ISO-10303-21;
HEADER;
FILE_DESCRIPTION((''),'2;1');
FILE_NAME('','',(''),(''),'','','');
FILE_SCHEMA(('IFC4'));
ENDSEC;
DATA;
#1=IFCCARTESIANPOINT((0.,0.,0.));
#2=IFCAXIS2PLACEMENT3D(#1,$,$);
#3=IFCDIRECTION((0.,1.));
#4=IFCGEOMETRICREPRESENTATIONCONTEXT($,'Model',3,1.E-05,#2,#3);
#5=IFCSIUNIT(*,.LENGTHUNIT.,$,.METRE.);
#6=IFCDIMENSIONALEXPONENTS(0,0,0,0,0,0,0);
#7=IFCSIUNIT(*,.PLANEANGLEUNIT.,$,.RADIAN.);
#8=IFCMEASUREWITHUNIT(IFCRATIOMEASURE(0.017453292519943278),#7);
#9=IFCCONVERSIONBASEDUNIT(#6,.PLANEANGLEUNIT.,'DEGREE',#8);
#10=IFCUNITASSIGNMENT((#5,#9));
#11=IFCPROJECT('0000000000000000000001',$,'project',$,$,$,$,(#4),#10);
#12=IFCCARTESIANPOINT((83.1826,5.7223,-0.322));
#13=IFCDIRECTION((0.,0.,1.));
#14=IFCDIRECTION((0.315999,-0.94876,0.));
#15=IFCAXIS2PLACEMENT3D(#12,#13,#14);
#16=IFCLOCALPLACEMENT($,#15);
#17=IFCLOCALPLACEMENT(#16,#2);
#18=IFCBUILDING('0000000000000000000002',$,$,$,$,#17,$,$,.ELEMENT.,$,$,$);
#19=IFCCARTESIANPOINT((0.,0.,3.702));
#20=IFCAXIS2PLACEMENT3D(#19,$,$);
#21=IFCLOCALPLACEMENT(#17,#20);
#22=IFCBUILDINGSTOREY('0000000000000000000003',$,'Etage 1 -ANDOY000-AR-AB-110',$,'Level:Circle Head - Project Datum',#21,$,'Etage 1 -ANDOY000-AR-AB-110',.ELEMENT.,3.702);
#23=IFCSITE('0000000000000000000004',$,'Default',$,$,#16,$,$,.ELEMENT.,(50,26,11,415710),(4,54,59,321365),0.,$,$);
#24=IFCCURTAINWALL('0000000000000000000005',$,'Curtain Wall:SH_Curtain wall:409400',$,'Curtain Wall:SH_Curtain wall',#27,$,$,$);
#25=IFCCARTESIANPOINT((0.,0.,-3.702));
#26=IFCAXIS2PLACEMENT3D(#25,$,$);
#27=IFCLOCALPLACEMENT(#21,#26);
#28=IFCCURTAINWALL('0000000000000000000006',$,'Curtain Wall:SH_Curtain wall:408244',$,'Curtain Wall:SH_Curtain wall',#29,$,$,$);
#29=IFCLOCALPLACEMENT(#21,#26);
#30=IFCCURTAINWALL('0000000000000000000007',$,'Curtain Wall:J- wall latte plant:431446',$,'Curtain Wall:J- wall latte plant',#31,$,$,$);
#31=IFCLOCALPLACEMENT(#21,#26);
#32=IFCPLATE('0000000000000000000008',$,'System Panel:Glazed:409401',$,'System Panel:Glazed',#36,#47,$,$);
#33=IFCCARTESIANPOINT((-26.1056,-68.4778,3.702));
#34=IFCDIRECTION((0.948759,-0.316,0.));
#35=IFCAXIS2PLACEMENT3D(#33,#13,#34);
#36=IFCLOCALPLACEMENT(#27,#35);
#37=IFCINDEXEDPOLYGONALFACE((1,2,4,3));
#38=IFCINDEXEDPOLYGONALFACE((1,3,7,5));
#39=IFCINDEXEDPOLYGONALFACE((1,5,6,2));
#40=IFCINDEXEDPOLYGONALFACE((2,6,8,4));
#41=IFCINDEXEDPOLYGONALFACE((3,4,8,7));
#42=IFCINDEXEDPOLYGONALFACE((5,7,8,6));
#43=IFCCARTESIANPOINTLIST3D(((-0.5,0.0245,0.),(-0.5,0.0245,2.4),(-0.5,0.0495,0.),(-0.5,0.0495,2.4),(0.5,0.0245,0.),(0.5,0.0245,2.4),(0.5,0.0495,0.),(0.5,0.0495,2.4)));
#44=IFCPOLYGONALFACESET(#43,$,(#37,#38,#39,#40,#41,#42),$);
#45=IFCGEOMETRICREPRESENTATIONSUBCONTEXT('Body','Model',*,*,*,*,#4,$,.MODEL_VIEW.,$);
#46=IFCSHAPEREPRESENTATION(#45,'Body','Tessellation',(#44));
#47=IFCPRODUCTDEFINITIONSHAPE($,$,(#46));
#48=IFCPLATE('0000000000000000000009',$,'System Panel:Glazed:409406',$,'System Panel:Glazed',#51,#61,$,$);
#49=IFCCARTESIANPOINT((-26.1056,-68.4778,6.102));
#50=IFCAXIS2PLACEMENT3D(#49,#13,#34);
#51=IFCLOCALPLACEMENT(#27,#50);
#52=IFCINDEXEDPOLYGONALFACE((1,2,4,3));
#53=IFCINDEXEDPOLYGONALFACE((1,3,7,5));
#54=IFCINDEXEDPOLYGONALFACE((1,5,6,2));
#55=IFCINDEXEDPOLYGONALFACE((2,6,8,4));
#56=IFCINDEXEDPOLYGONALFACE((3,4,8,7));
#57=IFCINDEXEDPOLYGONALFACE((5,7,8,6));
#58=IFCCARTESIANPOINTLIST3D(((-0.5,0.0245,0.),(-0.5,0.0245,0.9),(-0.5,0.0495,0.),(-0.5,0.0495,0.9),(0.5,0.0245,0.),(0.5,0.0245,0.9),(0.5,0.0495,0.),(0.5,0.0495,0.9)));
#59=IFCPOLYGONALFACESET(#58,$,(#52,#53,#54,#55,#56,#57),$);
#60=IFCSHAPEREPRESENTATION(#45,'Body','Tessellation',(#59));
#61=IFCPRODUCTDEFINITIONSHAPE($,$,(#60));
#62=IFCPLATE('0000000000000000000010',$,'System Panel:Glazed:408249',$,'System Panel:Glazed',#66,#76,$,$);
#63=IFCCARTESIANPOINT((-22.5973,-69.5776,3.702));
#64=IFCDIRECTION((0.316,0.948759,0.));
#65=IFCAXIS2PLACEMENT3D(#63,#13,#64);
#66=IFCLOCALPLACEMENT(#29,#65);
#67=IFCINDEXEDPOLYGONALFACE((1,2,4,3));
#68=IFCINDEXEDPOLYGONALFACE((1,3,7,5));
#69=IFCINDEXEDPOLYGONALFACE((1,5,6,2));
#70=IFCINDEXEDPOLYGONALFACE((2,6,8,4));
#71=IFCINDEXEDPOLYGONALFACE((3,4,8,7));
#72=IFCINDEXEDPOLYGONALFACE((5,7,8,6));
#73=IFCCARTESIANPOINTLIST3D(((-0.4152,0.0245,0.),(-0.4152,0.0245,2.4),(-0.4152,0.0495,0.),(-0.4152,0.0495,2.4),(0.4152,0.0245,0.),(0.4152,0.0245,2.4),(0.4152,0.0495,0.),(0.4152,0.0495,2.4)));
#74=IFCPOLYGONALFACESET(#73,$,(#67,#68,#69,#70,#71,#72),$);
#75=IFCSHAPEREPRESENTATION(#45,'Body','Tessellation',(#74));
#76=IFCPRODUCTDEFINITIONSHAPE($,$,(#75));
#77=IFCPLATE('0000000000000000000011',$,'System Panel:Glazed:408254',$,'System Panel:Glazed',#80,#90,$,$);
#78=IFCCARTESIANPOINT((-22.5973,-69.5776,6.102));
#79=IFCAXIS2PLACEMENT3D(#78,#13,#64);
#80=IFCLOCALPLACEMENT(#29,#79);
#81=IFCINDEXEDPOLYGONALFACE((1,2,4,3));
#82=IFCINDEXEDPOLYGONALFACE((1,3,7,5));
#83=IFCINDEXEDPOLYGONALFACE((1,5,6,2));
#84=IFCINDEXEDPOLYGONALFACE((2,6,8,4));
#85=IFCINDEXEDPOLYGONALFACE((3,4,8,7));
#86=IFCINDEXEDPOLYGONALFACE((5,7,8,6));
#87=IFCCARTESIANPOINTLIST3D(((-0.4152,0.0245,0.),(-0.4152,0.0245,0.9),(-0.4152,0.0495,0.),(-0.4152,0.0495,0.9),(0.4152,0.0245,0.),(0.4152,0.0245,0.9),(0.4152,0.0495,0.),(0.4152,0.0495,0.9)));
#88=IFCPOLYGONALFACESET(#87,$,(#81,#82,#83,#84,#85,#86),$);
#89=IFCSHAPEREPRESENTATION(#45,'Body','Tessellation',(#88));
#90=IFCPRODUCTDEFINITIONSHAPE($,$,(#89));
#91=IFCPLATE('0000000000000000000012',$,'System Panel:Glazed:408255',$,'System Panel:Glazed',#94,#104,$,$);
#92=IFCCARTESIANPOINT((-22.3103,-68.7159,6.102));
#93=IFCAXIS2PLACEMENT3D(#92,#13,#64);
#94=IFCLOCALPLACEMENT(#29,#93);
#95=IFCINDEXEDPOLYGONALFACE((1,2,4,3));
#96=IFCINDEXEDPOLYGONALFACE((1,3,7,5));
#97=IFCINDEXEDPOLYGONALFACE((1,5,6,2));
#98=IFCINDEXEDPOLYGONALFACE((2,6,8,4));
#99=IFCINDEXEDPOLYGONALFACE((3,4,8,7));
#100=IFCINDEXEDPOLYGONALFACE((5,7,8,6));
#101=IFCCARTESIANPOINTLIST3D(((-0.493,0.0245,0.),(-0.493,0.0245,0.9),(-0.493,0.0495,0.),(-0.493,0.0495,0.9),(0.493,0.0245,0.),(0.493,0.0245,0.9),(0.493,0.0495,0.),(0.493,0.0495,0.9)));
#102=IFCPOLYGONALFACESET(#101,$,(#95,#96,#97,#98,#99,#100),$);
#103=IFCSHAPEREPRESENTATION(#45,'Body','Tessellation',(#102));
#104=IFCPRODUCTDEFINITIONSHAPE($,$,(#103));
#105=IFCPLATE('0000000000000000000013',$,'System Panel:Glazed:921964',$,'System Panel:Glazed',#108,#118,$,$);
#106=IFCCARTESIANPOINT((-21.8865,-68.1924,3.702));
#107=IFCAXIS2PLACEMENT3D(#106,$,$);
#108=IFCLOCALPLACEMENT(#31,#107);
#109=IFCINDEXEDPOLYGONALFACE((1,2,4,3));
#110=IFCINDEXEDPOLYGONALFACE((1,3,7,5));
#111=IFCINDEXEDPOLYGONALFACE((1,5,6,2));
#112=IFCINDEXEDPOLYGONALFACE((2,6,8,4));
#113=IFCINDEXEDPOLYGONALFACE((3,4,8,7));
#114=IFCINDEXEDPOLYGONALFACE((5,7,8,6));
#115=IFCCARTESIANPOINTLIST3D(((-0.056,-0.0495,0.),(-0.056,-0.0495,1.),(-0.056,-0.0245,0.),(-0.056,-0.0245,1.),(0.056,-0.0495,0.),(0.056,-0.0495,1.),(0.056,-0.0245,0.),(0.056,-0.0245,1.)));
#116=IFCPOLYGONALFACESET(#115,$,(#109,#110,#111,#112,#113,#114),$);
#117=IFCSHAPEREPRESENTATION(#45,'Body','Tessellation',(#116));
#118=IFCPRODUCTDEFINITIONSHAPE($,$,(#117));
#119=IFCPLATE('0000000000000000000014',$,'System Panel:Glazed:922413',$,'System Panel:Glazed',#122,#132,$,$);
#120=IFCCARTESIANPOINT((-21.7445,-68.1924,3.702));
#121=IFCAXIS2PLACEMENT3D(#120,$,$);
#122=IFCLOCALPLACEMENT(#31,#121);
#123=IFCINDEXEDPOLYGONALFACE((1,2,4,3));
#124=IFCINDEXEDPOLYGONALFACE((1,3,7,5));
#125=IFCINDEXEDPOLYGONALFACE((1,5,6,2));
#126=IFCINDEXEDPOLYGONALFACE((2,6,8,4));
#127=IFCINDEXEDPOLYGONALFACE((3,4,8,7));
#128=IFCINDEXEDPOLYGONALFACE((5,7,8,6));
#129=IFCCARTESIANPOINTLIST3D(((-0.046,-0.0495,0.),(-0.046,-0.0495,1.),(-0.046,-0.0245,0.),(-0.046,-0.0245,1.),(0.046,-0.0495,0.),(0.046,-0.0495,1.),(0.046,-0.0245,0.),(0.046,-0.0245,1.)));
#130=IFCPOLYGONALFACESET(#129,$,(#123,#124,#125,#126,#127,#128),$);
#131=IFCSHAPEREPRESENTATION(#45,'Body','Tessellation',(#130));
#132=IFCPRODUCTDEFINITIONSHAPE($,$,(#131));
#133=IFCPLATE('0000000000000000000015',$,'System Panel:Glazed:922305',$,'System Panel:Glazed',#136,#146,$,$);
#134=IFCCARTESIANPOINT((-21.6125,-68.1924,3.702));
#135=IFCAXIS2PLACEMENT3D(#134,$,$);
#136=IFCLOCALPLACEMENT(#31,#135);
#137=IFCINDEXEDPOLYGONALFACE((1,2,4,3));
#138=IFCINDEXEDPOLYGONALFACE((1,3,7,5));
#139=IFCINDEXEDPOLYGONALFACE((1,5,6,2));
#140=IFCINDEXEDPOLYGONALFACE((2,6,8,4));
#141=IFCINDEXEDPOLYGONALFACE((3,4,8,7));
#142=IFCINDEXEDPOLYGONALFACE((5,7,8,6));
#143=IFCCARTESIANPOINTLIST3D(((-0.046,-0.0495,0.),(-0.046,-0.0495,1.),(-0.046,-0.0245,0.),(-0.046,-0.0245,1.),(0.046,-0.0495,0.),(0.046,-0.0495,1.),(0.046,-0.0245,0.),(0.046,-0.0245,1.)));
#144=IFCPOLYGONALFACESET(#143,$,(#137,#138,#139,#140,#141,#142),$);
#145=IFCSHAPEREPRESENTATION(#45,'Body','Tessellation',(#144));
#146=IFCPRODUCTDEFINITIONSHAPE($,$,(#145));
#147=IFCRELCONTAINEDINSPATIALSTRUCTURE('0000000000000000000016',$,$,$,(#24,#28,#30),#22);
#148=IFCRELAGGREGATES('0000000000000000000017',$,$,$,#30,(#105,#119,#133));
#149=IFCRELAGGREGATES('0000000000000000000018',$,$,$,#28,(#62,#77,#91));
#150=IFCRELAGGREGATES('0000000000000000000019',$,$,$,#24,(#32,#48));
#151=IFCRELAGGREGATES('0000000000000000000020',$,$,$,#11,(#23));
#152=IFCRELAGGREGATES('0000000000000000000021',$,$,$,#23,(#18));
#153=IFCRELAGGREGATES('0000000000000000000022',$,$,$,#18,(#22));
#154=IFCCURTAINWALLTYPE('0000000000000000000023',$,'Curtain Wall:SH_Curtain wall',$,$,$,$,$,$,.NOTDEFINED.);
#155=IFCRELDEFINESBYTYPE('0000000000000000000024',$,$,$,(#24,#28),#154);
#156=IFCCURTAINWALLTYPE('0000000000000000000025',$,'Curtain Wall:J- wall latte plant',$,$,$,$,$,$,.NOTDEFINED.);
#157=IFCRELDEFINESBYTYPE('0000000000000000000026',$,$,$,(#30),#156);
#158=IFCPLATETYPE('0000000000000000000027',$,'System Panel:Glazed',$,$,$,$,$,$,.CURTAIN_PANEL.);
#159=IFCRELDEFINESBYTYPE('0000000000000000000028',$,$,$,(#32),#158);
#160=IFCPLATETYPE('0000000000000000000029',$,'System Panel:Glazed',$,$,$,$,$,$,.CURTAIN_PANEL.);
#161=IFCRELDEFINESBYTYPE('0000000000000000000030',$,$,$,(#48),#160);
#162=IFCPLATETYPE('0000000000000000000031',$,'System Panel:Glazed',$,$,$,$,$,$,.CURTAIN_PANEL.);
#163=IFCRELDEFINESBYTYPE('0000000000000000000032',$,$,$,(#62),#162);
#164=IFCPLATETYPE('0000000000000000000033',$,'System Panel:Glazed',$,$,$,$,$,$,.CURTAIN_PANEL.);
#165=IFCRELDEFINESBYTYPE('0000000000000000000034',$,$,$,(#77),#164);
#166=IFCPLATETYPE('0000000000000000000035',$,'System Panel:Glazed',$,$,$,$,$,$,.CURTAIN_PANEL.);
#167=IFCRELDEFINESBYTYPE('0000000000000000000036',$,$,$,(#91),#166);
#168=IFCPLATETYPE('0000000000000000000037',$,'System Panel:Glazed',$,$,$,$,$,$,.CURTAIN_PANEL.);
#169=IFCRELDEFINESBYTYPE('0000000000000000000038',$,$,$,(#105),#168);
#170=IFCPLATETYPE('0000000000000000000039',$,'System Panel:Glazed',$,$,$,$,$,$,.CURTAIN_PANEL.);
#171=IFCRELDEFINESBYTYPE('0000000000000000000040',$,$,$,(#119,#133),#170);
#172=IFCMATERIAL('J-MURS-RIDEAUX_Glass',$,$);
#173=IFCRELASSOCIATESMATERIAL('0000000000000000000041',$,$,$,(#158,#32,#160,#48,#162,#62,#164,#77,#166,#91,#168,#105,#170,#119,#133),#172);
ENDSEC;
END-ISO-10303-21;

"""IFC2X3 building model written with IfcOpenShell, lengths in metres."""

from ifc_helpers import new_model, entity, si_unit, converted_unit, direction, frame, frame_2d, origin, place, context, subcontext, project, spatial, rectangle, extrude, source, transform, mapped, material, type_object, type_shapes, element, aggregate, save


model = new_model("IFC2X3")

# Units and contexts
model_context = context("Model", 3, precision=1e-05, world=origin(), true_north=direction((0.0, 1.0)))
body_context = subcontext(model_context, "Body", "Model", "MODEL_VIEW")
ifc_project = project(units=[si_unit("LENGTHUNIT", "METRE"), converted_unit("PLANEANGLEUNIT", "DEGREE", entity("IfcRatioMeasure", 0.017453292519943278), si_unit("PLANEANGLEUNIT", "RADIAN"), dimensions=[0, 0, 0, 0, 0, 0, 0])], contexts=[model_context])

# Site, building, storey
site_placement = place(None, frame((83.1826, 5.7223, -0.322), z_axis=(0.0, 0.0, 1.0), x_axis=(0.315999, -0.94876, 0.0)))
site = spatial("IfcSite", under=ifc_project, at=site_placement, Name="Default", CompositionType="ELEMENT", RefLatitude=(50, 26, 11, 415710), RefLongitude=(4, 54, 59, 321365), RefElevation=0.0)
building_placement = place(site_placement, origin())
building = spatial("IfcBuilding", under=site, at=building_placement, CompositionType="ELEMENT")
storey_placement = place(building_placement, frame((0.0, 0.0, 3.702)))
storey = spatial("IfcBuildingStorey", under=building, at=storey_placement, Name="Etage 1 -ANDOY000-AR-AB-110", ObjectType="Level:Circle Head - Project Datum", LongName="Etage 1 -ANDOY000-AR-AB-110", CompositionType="ELEMENT", Elevation=3.702)

# Curtain wall
curtain_wall_type_1 = type_object("IfcCurtainWallType", Name="Curtain Wall:SH_Curtain wall", PredefinedType="NOTDEFINED")
curtain_wall_1_placement = place(storey_placement, frame((0.0, 0.0, -3.702)))
curtain_wall_1 = element("IfcCurtainWall", 1, at=curtain_wall_1_placement, inside=storey, type_object=curtain_wall_type_1, Name="Curtain Wall:SH_Curtain wall:409400", ObjectType="Curtain Wall:SH_Curtain wall")

# Curtain wall
curtain_wall_2_placement = place(storey_placement, frame((0.0, 0.0, -3.702)))
curtain_wall_2 = element("IfcCurtainWall", 2, at=curtain_wall_2_placement, inside=storey, type_object=curtain_wall_type_1, Name="Curtain Wall:SH_Curtain wall:408244", ObjectType="Curtain Wall:SH_Curtain wall")

# Curtain wall
curtain_wall_type_2 = type_object("IfcCurtainWallType", Name="Curtain Wall:J- wall latte plant", PredefinedType="NOTDEFINED")
curtain_wall_3_placement = place(storey_placement, frame((0.0, 0.0, -3.702)))
curtain_wall_3 = element("IfcCurtainWall", 3, at=curtain_wall_3_placement, inside=storey, type_object=curtain_wall_type_2, Name="Curtain Wall:J- wall latte plant:431446", ObjectType="Curtain Wall:J- wall latte plant")

# Plates
ifc_material_1 = material(Name="J-MURS-RIDEAUX_Glass")
plate_type_1 = type_object("IfcPlateType", Name="System Panel:Glazed", PredefinedType="CURTAIN_PANEL", material=ifc_material_1)
shared_shape_1 = source(origin(), body_context, "Body", "SweptSolid", [
    extrude(rectangle(XDim=0.025, YDim=1.0, at=frame_2d((0.0, 0.0), x_axis=(1.0, 0.0))), frame((0.0, 0.037, 0.0), z_axis=(0.0, 0.0, 1.0), x_axis=(0.0, 1.0, 0.0)), (0.0, 0.0, 1.0), 2.4),
])
type_shapes(plate_type_1, [shared_shape_1])
plate_1_placement = place(curtain_wall_1_placement, frame((-26.1056, -68.4778, 3.702), z_axis=(0.0, 0.0, 1.0), x_axis=(0.948759, -0.316, 0.0)))
plate_1 = element("IfcPlate", 4, at=plate_1_placement, type_object=plate_type_1, material=ifc_material_1, Name="System Panel:Glazed:409401", ObjectType="System Panel:Glazed", context=body_context, shape_type="MappedRepresentation", body=[
    mapped(shared_shape_1, transform((0.0, 0.0, 0.0), scale=1.0)),
])
plate_type_2 = type_object("IfcPlateType", Name="System Panel:Glazed", PredefinedType="CURTAIN_PANEL", material=ifc_material_1)
shared_shape_2 = source(origin(), body_context, "Body", "SweptSolid", [
    extrude(rectangle(XDim=0.025, YDim=1.0, at=frame_2d((0.0, 0.0), x_axis=(1.0, 0.0))), frame((0.0, 0.037, 0.0), z_axis=(0.0, 0.0, 1.0), x_axis=(0.0, 1.0, 0.0)), (0.0, 0.0, 1.0), 0.9),
])
type_shapes(plate_type_2, [shared_shape_2])
plate_2_placement = place(curtain_wall_1_placement, frame((-26.1056, -68.4778, 6.102), z_axis=(0.0, 0.0, 1.0), x_axis=(0.948759, -0.316, 0.0)))
plate_2 = element("IfcPlate", 5, at=plate_2_placement, type_object=plate_type_2, material=ifc_material_1, Name="System Panel:Glazed:409406", ObjectType="System Panel:Glazed", context=body_context, shape_type="MappedRepresentation", body=[
    mapped(shared_shape_2, transform((0.0, 0.0, 0.0), scale=1.0)),
])
plate_type_3 = type_object("IfcPlateType", Name="System Panel:Glazed", PredefinedType="CURTAIN_PANEL", material=ifc_material_1)
shared_shape_3 = source(origin(), body_context, "Body", "SweptSolid", [
    extrude(rectangle(XDim=0.025, YDim=0.8305, at=frame_2d((0.0, 0.0), x_axis=(1.0, 0.0))), frame((0.0, 0.037, 0.0), z_axis=(0.0, 0.0, 1.0), x_axis=(0.0, 1.0, 0.0)), (0.0, 0.0, 1.0), 2.4),
])
type_shapes(plate_type_3, [shared_shape_3])
plate_3_placement = place(curtain_wall_2_placement, frame((-22.5973, -69.5776, 3.702), z_axis=(0.0, 0.0, 1.0), x_axis=(0.316, 0.948759, 0.0)))
plate_3 = element("IfcPlate", 6, at=plate_3_placement, type_object=plate_type_3, material=ifc_material_1, Name="System Panel:Glazed:408249", ObjectType="System Panel:Glazed", context=body_context, shape_type="MappedRepresentation", body=[
    mapped(shared_shape_3, transform((0.0, 0.0, 0.0), scale=1.0)),
])
plate_type_4 = type_object("IfcPlateType", Name="System Panel:Glazed", PredefinedType="CURTAIN_PANEL", material=ifc_material_1)
shared_shape_4 = source(origin(), body_context, "Body", "SweptSolid", [
    extrude(rectangle(XDim=0.025, YDim=0.8305, at=frame_2d((0.0, 0.0), x_axis=(1.0, 0.0))), frame((0.0, 0.037, 0.0), z_axis=(0.0, 0.0, 1.0), x_axis=(0.0, 1.0, 0.0)), (0.0, 0.0, 1.0), 0.9),
])
type_shapes(plate_type_4, [shared_shape_4])
plate_4_placement = place(curtain_wall_2_placement, frame((-22.5973, -69.5776, 6.102), z_axis=(0.0, 0.0, 1.0), x_axis=(0.316, 0.948759, 0.0)))
plate_4 = element("IfcPlate", 7, at=plate_4_placement, type_object=plate_type_4, material=ifc_material_1, Name="System Panel:Glazed:408254", ObjectType="System Panel:Glazed", context=body_context, shape_type="MappedRepresentation", body=[
    mapped(shared_shape_4, transform((0.0, 0.0, 0.0), scale=1.0)),
])
plate_type_5 = type_object("IfcPlateType", Name="System Panel:Glazed", PredefinedType="CURTAIN_PANEL", material=ifc_material_1)
shared_shape_5 = source(origin(), body_context, "Body", "SweptSolid", [
    extrude(rectangle(XDim=0.025, YDim=0.9859, at=frame_2d((0.0, 0.0), x_axis=(1.0, 0.0))), frame((0.0, 0.037, 0.0), z_axis=(0.0, 0.0, 1.0), x_axis=(0.0, 1.0, 0.0)), (0.0, 0.0, 1.0), 0.9),
])
type_shapes(plate_type_5, [shared_shape_5])
plate_5_placement = place(curtain_wall_2_placement, frame((-22.3103, -68.7159, 6.102), z_axis=(0.0, 0.0, 1.0), x_axis=(0.316, 0.948759, 0.0)))
plate_5 = element("IfcPlate", 8, at=plate_5_placement, type_object=plate_type_5, material=ifc_material_1, Name="System Panel:Glazed:408255", ObjectType="System Panel:Glazed", context=body_context, shape_type="MappedRepresentation", body=[
    mapped(shared_shape_5, transform((0.0, 0.0, 0.0), scale=1.0)),
])
plate_type_6 = type_object("IfcPlateType", Name="System Panel:Glazed", PredefinedType="CURTAIN_PANEL", material=ifc_material_1)
shared_shape_6 = source(origin(), body_context, "Body", "SweptSolid", [
    extrude(rectangle(XDim=0.025, YDim=0.112, at=frame_2d((0.0, 0.0), x_axis=(1.0, 0.0))), frame((0.0, -0.037, 0.0), z_axis=(0.0, 0.0, 1.0), x_axis=(0.0, 1.0, 0.0)), (0.0, 0.0, 1.0), 1.0),
])
type_shapes(plate_type_6, [shared_shape_6])
plate_6_placement = place(curtain_wall_3_placement, frame((-21.8865, -68.1924, 3.702)))
plate_6 = element("IfcPlate", 9, at=plate_6_placement, type_object=plate_type_6, material=ifc_material_1, Name="System Panel:Glazed:921964", ObjectType="System Panel:Glazed", context=body_context, shape_type="MappedRepresentation", body=[
    mapped(shared_shape_6, transform((0.0, 0.0, 0.0), scale=1.0)),
])
plate_type_7 = type_object("IfcPlateType", Name="System Panel:Glazed", PredefinedType="CURTAIN_PANEL", material=ifc_material_1)
shared_shape_7 = source(origin(), body_context, "Body", "SweptSolid", [
    extrude(rectangle(XDim=0.025, YDim=0.092, at=frame_2d((0.0, 0.0), x_axis=(1.0, 0.0))), frame((0.0, -0.037, 0.0), z_axis=(0.0, 0.0, 1.0), x_axis=(0.0, 1.0, 0.0)), (0.0, 0.0, 1.0), 1.0),
])
type_shapes(plate_type_7, [shared_shape_7])
plate_7_placement = place(curtain_wall_3_placement, frame((-21.7445, -68.1924, 3.702)))
plate_7 = element("IfcPlate", 10, at=plate_7_placement, type_object=plate_type_7, material=ifc_material_1, Name="System Panel:Glazed:922413", ObjectType="System Panel:Glazed", context=body_context, shape_type="MappedRepresentation", body=[
    mapped(shared_shape_7, transform((0.0, 0.0, 0.0), scale=1.0)),
])
plate_8_placement = place(curtain_wall_3_placement, frame((-21.6125, -68.1924, 3.702)))
plate_8 = element("IfcPlate", 11, at=plate_8_placement, type_object=plate_type_7, material=ifc_material_1, Name="System Panel:Glazed:922305", ObjectType="System Panel:Glazed", context=body_context, shape_type="MappedRepresentation", body=[
    mapped(shared_shape_7, transform((0.0, 0.0, 0.0), scale=1.0)),
])
aggregate(curtain_wall_3, [plate_6, plate_7, plate_8])

aggregate(curtain_wall_2, [plate_3, plate_4, plate_5])
aggregate(curtain_wall_1, [plate_1, plate_2])

save(model, "model.ifc")
